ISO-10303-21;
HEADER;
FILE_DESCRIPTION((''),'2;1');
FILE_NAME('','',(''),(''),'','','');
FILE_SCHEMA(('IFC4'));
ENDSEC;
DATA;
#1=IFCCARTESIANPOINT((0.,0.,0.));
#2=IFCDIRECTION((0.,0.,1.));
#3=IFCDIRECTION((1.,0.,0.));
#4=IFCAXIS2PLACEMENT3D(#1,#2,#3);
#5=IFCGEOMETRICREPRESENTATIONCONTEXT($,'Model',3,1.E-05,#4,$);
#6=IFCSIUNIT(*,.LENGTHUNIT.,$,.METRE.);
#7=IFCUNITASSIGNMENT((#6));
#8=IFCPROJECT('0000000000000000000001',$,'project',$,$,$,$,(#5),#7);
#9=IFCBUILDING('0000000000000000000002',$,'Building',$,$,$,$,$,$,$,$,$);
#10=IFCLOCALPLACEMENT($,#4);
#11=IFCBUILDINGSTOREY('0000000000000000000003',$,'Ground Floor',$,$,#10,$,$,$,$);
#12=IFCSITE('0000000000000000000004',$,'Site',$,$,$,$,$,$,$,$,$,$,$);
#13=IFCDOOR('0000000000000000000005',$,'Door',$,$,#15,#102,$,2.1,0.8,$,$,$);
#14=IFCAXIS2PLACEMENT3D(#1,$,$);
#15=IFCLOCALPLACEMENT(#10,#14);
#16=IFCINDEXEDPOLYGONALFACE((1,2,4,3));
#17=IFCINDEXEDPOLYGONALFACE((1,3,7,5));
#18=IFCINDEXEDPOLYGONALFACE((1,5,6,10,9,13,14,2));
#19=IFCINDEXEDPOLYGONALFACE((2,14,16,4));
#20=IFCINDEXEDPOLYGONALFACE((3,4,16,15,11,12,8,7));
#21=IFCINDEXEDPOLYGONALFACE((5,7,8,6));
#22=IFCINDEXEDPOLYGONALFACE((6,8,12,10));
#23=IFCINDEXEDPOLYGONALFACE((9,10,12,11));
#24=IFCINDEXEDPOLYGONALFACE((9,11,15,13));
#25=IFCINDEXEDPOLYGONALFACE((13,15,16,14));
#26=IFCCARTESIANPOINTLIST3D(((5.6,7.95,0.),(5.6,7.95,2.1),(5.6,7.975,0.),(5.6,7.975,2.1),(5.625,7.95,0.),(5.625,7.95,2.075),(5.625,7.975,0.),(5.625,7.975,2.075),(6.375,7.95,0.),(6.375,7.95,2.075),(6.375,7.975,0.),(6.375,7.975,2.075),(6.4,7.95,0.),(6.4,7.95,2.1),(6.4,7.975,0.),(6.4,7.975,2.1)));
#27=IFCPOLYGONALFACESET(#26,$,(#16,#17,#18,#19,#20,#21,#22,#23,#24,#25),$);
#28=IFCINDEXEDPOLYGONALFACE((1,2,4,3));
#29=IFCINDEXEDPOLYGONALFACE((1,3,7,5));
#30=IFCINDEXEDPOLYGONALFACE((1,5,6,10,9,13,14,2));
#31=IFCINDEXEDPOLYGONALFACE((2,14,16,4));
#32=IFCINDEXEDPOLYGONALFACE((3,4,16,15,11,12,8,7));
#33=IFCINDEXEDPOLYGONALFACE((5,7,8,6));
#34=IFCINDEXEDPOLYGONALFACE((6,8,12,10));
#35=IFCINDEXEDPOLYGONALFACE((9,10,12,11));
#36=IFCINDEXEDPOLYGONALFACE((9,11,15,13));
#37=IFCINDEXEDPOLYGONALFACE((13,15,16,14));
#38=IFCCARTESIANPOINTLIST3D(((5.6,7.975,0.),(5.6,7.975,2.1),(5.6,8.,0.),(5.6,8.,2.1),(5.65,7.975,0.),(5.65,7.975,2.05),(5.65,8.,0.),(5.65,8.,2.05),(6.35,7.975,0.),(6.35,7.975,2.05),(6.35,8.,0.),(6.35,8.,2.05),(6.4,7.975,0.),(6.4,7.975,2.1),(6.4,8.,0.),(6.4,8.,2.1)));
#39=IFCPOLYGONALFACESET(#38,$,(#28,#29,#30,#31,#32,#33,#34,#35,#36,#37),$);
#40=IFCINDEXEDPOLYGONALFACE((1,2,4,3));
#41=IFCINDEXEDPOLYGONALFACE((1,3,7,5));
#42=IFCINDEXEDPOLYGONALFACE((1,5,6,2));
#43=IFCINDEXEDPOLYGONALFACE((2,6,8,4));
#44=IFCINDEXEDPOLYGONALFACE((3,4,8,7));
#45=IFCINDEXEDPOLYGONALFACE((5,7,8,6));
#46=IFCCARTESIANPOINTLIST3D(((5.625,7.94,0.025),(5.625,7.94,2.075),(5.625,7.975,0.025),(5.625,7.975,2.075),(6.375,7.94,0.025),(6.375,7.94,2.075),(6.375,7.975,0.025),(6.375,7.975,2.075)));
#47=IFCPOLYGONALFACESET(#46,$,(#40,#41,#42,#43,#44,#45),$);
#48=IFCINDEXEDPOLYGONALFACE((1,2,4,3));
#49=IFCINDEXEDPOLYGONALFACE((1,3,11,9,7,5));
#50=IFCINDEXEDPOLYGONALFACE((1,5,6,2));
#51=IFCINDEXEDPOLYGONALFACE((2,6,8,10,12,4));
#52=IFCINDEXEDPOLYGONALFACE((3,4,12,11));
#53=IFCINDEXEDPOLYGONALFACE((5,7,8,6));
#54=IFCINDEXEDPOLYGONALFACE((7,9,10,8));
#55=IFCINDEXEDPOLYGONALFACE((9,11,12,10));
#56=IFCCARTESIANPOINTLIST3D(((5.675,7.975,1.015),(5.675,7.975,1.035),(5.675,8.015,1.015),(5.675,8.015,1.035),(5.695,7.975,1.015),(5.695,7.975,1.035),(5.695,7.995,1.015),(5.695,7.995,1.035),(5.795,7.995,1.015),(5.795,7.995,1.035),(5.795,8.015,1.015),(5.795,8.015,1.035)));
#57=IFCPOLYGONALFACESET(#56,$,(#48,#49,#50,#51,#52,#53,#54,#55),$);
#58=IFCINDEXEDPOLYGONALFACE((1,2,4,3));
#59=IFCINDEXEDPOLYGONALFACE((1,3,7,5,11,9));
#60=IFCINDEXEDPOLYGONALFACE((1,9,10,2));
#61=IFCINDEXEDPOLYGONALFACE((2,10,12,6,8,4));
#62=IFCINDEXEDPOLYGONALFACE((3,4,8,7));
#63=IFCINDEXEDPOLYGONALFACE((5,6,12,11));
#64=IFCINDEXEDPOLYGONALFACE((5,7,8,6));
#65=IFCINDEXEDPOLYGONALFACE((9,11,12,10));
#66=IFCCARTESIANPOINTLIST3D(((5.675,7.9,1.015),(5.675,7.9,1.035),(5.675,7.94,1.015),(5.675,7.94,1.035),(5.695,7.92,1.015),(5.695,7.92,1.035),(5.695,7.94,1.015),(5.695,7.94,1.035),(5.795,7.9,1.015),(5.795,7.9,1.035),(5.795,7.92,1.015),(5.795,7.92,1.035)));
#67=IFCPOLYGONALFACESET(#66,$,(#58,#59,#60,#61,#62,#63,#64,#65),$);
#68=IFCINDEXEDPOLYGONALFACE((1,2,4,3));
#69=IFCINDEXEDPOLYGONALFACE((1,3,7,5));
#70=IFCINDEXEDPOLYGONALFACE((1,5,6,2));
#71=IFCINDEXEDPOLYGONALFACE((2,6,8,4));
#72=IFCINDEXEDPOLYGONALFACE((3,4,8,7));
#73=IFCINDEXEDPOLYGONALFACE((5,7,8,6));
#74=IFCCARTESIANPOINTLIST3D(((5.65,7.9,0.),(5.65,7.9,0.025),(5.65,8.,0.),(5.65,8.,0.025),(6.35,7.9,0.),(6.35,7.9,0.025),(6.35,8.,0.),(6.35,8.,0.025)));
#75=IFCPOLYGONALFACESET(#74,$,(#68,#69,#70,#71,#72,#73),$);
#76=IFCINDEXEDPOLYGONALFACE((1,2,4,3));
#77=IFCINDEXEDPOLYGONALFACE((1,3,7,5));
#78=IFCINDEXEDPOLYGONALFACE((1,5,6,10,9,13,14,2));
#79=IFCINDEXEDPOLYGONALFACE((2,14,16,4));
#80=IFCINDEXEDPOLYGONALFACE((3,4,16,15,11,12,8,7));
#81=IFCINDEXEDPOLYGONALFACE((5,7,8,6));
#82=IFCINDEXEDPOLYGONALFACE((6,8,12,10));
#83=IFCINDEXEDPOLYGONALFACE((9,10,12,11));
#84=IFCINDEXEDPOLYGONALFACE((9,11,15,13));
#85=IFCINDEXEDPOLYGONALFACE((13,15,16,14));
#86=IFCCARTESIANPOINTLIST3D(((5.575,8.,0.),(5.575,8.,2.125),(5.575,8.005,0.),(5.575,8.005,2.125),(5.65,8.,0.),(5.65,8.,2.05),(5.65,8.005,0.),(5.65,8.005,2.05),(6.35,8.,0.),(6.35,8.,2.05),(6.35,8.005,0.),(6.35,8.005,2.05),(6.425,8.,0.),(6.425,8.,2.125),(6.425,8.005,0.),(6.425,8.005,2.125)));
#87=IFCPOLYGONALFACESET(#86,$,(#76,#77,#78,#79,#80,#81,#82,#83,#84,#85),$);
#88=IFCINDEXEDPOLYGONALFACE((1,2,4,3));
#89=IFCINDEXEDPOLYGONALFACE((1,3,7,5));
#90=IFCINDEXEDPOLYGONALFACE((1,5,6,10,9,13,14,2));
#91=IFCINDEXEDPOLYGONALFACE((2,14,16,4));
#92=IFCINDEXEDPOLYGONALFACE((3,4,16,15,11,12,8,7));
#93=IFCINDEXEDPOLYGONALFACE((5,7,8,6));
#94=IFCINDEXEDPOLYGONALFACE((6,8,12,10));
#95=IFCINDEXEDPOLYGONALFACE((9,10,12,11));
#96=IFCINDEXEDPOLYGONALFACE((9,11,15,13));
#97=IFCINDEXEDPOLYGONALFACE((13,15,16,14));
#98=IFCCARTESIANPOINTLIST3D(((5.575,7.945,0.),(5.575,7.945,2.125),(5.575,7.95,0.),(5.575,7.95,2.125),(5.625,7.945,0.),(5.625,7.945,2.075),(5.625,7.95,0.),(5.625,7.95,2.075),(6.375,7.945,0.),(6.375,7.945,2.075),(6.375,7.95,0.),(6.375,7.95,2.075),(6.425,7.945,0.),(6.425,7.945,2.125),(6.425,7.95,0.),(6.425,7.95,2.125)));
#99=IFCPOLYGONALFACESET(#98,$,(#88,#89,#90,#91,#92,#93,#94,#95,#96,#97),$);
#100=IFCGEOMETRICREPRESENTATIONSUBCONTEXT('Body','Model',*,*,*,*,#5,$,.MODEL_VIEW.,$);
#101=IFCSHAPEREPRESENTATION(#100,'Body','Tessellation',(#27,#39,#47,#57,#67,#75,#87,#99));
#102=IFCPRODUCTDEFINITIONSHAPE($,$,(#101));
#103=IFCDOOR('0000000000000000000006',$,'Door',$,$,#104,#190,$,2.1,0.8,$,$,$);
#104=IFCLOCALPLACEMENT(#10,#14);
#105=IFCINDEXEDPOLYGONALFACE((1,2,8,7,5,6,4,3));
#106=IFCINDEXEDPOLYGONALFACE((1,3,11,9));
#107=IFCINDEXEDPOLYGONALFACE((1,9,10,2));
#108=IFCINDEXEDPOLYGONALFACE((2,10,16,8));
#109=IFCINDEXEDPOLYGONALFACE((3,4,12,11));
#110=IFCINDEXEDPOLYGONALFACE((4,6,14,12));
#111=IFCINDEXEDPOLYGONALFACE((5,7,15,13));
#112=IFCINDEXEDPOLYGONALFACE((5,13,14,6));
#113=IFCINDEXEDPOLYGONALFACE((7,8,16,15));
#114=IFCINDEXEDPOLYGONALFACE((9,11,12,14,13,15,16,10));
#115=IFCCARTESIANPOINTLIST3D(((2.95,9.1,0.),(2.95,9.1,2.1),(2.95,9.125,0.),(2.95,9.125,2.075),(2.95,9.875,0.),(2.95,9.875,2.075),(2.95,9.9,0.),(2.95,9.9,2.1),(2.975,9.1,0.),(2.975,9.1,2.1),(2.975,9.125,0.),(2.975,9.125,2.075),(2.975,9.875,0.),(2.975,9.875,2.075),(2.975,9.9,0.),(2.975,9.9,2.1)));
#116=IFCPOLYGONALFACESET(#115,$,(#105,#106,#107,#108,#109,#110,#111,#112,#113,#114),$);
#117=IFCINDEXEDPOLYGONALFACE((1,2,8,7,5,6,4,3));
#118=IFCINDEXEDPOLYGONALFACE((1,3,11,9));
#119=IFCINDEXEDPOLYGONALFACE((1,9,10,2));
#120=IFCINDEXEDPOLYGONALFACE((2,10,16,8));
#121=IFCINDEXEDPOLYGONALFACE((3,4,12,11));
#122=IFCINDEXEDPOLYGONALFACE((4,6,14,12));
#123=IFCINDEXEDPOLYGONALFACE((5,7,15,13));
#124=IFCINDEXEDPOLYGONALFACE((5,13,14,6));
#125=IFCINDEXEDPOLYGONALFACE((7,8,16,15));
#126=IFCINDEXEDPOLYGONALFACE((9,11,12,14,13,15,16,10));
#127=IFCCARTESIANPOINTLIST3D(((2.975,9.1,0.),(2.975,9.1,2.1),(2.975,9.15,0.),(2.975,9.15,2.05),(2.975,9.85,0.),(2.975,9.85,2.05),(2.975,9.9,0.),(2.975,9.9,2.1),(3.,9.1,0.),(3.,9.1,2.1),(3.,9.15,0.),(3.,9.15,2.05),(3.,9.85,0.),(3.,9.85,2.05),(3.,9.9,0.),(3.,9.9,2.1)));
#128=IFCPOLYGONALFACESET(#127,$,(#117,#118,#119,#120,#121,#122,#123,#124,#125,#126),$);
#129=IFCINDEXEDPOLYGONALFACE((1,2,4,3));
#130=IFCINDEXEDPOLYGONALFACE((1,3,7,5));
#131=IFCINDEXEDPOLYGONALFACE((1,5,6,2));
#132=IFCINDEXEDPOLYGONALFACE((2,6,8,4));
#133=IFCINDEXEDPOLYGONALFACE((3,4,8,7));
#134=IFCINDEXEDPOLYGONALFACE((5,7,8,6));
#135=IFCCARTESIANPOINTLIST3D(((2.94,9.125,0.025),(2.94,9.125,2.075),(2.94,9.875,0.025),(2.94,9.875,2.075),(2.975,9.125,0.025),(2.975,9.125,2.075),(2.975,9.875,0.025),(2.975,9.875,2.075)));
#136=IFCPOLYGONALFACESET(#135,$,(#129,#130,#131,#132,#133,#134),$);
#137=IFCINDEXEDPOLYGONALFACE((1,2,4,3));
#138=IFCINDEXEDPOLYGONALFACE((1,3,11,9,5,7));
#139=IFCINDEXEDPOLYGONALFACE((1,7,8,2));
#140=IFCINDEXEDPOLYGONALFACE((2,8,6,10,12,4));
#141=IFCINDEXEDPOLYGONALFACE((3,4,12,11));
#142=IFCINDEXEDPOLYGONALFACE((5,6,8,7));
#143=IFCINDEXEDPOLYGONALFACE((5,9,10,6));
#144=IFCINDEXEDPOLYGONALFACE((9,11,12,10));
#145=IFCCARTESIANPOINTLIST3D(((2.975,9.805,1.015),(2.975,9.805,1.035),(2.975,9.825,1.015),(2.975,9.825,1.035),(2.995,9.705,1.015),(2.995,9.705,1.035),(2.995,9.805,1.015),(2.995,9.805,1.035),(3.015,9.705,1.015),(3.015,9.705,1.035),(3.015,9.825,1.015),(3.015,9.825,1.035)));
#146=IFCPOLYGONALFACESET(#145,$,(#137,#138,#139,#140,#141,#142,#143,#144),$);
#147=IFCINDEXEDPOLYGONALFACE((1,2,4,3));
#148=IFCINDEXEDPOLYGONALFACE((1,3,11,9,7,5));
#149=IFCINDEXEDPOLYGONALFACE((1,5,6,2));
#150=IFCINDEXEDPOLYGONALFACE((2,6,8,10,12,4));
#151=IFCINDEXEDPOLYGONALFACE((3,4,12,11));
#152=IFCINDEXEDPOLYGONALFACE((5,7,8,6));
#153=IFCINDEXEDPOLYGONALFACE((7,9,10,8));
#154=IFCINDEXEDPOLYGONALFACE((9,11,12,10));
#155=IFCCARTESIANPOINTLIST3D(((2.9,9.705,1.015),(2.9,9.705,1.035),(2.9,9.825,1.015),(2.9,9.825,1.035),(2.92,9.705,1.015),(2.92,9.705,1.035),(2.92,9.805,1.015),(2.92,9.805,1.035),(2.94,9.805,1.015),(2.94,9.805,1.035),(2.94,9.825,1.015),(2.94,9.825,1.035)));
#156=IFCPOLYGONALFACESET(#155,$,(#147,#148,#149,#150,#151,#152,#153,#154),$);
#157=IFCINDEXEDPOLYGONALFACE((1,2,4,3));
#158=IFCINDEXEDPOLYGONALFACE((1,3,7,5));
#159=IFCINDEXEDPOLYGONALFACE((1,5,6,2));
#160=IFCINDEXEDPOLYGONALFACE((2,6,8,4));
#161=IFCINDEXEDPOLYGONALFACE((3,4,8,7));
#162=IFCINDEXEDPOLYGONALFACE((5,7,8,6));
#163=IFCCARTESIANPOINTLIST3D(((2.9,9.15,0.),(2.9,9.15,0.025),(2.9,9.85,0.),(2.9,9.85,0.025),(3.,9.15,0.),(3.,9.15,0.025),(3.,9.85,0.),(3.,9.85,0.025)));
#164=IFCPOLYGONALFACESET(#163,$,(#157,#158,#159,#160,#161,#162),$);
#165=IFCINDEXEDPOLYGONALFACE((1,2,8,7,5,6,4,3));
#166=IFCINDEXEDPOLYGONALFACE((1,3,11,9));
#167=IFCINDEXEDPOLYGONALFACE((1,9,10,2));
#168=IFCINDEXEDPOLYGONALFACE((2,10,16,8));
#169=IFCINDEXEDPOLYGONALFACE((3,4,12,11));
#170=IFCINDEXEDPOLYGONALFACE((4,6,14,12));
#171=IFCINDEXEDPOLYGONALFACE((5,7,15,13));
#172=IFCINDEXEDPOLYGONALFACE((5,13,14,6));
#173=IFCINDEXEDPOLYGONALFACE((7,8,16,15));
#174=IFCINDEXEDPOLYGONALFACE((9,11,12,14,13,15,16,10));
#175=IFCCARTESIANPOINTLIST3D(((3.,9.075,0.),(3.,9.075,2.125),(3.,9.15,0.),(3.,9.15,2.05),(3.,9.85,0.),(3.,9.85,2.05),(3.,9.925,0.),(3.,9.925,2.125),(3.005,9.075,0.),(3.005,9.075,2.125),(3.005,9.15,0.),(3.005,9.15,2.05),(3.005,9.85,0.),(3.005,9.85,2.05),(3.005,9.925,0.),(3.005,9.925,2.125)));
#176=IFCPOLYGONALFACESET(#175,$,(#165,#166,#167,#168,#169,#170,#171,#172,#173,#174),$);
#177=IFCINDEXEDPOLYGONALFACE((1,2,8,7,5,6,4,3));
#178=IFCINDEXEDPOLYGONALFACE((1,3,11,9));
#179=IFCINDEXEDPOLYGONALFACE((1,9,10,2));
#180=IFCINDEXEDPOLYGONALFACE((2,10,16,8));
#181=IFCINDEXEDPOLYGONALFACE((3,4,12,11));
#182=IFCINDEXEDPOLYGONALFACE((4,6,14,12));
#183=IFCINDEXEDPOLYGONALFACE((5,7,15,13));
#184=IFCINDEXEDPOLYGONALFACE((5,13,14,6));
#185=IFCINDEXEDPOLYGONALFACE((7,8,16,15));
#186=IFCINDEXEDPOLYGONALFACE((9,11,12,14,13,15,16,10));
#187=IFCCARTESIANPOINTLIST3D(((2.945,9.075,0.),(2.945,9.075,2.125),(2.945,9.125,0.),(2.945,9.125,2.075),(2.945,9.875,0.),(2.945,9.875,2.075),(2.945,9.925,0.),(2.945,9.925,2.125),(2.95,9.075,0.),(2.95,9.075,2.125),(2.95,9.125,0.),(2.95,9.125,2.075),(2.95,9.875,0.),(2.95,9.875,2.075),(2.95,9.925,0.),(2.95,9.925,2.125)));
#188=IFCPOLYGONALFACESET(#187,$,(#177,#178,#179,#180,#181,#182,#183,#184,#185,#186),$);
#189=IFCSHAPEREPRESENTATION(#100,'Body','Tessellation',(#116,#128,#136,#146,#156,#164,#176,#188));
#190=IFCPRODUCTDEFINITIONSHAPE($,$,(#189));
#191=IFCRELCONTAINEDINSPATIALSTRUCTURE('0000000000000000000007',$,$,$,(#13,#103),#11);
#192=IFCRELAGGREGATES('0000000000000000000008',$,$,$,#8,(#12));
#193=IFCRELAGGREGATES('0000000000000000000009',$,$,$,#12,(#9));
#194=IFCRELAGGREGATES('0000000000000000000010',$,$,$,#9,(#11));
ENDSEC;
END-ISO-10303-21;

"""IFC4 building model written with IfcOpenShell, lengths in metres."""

from ifc_helpers import new_model, si_unit, frame, origin_with_axes, place, context, subcontext, project, spatial, line, indexed_curve, outline, extrude, element, save


model = new_model("IFC4")

# Units and contexts
model_context = context("Model", 3, precision=1e-05, world=origin_with_axes())
body_context = subcontext(model_context, "Body", "Model", "MODEL_VIEW")
ifc_project = project(units=[si_unit("LENGTHUNIT", "METRE")], contexts=[model_context])

# Site, building, storey
site = spatial("IfcSite", under=ifc_project, Name="Site")
building = spatial("IfcBuilding", under=site, Name="Building")
storey_placement = place(None, origin_with_axes())
storey = spatial("IfcBuildingStorey", under=building, at=storey_placement, Name="Ground Floor")

# Doors
door_1_placement = place(storey_placement, frame((6.4, 8.0, 0.0), z_axis=(0.0, 0.0, 1.0), x_axis=(-1.0, 0.0, 0.0)))
element("IfcDoor", 1, at=door_1_placement, inside=storey, Name="Door", OverallHeight=2.1, OverallWidth=0.8, context=body_context, shape_type="SweptSolid", body=[
    extrude(outline(indexed_curve([(0.0, 0.0), (0.0, 2.1), (0.8, 2.1), (0.8, 0.0), (0.775, 0.0), (0.775, 2.075), (0.025, 2.075), (0.025, 0.0)], segments=[line(1, 2, 3, 4, 5, 6, 7, 8, 1)])), frame((0.0, 0.025, 0.0), z_axis=(0.0, -1.0, 0.0), x_axis=(1.0, 0.0, 0.0)), (0.0, 0.0, -1.0), 0.025),
    extrude(outline(indexed_curve([(0.0, 0.0), (0.0, 2.1), (0.8, 2.1), (0.8, 0.0), (0.75, 0.0), (0.75, 2.05), (0.05, 2.05), (0.05, 0.0)], segments=[line(1, 2, 3, 4, 5, 6, 7, 8, 1)])), frame((0.0, 0.0, 0.0), z_axis=(0.0, -1.0, 0.0), x_axis=(1.0, 0.0, 0.0)), (0.0, 0.0, -1.0), 0.025),
    extrude(outline(indexed_curve([(0.0, 0.0), (0.75, 0.0), (0.75, 0.035), (0.0, 0.035)], segments=[line(1, 2, 3, 4, 1)])), frame((0.025, 0.025, 0.025), z_axis=(0.0, 0.0, 1.0), x_axis=(1.0, 0.0, 0.0)), (0.0, 0.0, 1.0), 2.05),
    extrude(outline(indexed_curve([(0.0, 0.0), (0.0, -0.04), (-0.12, -0.04), (-0.12, -0.02), (-0.02, -0.02), (-0.02, 0.0)], segments=[line(1, 2, 3, 4, 5, 6, 1)])), frame((0.725, 0.025, 1.015), z_axis=(0.0, 0.0, 1.0), x_axis=(1.0, 0.0, 0.0)), (0.0, 0.0, 1.0), 0.02),
    extrude(outline(indexed_curve([(0.0, 0.0), (0.0, 0.04), (-0.12, 0.04), (-0.12, 0.02), (-0.02, 0.02), (-0.02, 0.0)], segments=[line(1, 2, 3, 4, 5, 6, 1)])), frame((0.725, 0.06, 1.015), z_axis=(0.0, 0.0, 1.0), x_axis=(1.0, 0.0, 0.0)), (0.0, 0.0, 1.0), 0.02),
    extrude(outline(indexed_curve([(0.0, 0.0), (0.7, 0.0), (0.7, 0.1), (0.0, 0.1)], segments=[line(1, 2, 3, 4, 1)])), frame((0.05, 0.0, 0.0), z_axis=(0.0, 0.0, 1.0), x_axis=(1.0, 0.0, 0.0)), (0.0, 0.0, 1.0), 0.025),
    extrude(outline(indexed_curve([(0.0, 0.0), (0.0, 2.125), (0.85, 2.125), (0.85, 0.0), (0.775, 0.0), (0.775, 2.05), (0.075, 2.05), (0.075, 0.0)], segments=[line(1, 2, 3, 4, 5, 6, 7, 8, 1)])), frame((-0.025, -0.005, 0.0), z_axis=(0.0, -1.0, 0.0), x_axis=(1.0, 0.0, 0.0)), (0.0, 0.0, -1.0), 0.005),
    extrude(outline(indexed_curve([(0.0, 0.0), (0.0, 2.125), (0.85, 2.125), (0.85, 0.0), (0.8, 0.0), (0.8, 2.075), (0.05, 2.075), (0.05, 0.0)], segments=[line(1, 2, 3, 4, 5, 6, 7, 8, 1)])), frame((-0.025, 0.05, 0.0), z_axis=(0.0, -1.0, 0.0), x_axis=(1.0, 0.0, 0.0)), (0.0, 0.0, -1.0), 0.005),
])
door_2_placement = place(storey_placement, frame((3.0, 9.1, 0.0), z_axis=(0.0, 0.0, 1.0), x_axis=(0.0, 1.0, 0.0)))
element("IfcDoor", 2, at=door_2_placement, inside=storey, Name="Door", OverallHeight=2.1, OverallWidth=0.8, context=body_context, shape_type="SweptSolid", body=[
    extrude(outline(indexed_curve([(0.0, 0.0), (0.0, 2.1), (0.8, 2.1), (0.8, 0.0), (0.775, 0.0), (0.775, 2.075), (0.025, 2.075), (0.025, 0.0)], segments=[line(1, 2, 3, 4, 5, 6, 7, 8, 1)])), frame((0.0, 0.025, 0.0), z_axis=(0.0, -1.0, 0.0), x_axis=(1.0, 0.0, 0.0)), (0.0, 0.0, -1.0), 0.025),
    extrude(outline(indexed_curve([(0.0, 0.0), (0.0, 2.1), (0.8, 2.1), (0.8, 0.0), (0.75, 0.0), (0.75, 2.05), (0.05, 2.05), (0.05, 0.0)], segments=[line(1, 2, 3, 4, 5, 6, 7, 8, 1)])), frame((0.0, 0.0, 0.0), z_axis=(0.0, -1.0, 0.0), x_axis=(1.0, 0.0, 0.0)), (0.0, 0.0, -1.0), 0.025),
    extrude(outline(indexed_curve([(0.0, 0.0), (0.75, 0.0), (0.75, 0.035), (0.0, 0.035)], segments=[line(1, 2, 3, 4, 1)])), frame((0.025, 0.025, 0.025), z_axis=(0.0, 0.0, 1.0), x_axis=(1.0, 0.0, 0.0)), (0.0, 0.0, 1.0), 2.05),
    extrude(outline(indexed_curve([(0.0, 0.0), (0.0, -0.04), (-0.12, -0.04), (-0.12, -0.02), (-0.02, -0.02), (-0.02, 0.0)], segments=[line(1, 2, 3, 4, 5, 6, 1)])), frame((0.725, 0.025, 1.015), z_axis=(0.0, 0.0, 1.0), x_axis=(1.0, 0.0, 0.0)), (0.0, 0.0, 1.0), 0.02),
    extrude(outline(indexed_curve([(0.0, 0.0), (0.0, 0.04), (-0.12, 0.04), (-0.12, 0.02), (-0.02, 0.02), (-0.02, 0.0)], segments=[line(1, 2, 3, 4, 5, 6, 1)])), frame((0.725, 0.06, 1.015), z_axis=(0.0, 0.0, 1.0), x_axis=(1.0, 0.0, 0.0)), (0.0, 0.0, 1.0), 0.02),
    extrude(outline(indexed_curve([(0.0, 0.0), (0.7, 0.0), (0.7, 0.1), (0.0, 0.1)], segments=[line(1, 2, 3, 4, 1)])), frame((0.05, 0.0, 0.0), z_axis=(0.0, 0.0, 1.0), x_axis=(1.0, 0.0, 0.0)), (0.0, 0.0, 1.0), 0.025),
    extrude(outline(indexed_curve([(0.0, 0.0), (0.0, 2.125), (0.85, 2.125), (0.85, 0.0), (0.775, 0.0), (0.775, 2.05), (0.075, 2.05), (0.075, 0.0)], segments=[line(1, 2, 3, 4, 5, 6, 7, 8, 1)])), frame((-0.025, -0.005, 0.0), z_axis=(0.0, -1.0, 0.0), x_axis=(1.0, 0.0, 0.0)), (0.0, 0.0, -1.0), 0.005),
    extrude(outline(indexed_curve([(0.0, 0.0), (0.0, 2.125), (0.85, 2.125), (0.85, 0.0), (0.8, 0.0), (0.8, 2.075), (0.05, 2.075), (0.05, 0.0)], segments=[line(1, 2, 3, 4, 5, 6, 7, 8, 1)])), frame((-0.025, 0.05, 0.0), z_axis=(0.0, -1.0, 0.0), x_axis=(1.0, 0.0, 0.0)), (0.0, 0.0, -1.0), 0.005),
])

save(model, "model.ifc")
